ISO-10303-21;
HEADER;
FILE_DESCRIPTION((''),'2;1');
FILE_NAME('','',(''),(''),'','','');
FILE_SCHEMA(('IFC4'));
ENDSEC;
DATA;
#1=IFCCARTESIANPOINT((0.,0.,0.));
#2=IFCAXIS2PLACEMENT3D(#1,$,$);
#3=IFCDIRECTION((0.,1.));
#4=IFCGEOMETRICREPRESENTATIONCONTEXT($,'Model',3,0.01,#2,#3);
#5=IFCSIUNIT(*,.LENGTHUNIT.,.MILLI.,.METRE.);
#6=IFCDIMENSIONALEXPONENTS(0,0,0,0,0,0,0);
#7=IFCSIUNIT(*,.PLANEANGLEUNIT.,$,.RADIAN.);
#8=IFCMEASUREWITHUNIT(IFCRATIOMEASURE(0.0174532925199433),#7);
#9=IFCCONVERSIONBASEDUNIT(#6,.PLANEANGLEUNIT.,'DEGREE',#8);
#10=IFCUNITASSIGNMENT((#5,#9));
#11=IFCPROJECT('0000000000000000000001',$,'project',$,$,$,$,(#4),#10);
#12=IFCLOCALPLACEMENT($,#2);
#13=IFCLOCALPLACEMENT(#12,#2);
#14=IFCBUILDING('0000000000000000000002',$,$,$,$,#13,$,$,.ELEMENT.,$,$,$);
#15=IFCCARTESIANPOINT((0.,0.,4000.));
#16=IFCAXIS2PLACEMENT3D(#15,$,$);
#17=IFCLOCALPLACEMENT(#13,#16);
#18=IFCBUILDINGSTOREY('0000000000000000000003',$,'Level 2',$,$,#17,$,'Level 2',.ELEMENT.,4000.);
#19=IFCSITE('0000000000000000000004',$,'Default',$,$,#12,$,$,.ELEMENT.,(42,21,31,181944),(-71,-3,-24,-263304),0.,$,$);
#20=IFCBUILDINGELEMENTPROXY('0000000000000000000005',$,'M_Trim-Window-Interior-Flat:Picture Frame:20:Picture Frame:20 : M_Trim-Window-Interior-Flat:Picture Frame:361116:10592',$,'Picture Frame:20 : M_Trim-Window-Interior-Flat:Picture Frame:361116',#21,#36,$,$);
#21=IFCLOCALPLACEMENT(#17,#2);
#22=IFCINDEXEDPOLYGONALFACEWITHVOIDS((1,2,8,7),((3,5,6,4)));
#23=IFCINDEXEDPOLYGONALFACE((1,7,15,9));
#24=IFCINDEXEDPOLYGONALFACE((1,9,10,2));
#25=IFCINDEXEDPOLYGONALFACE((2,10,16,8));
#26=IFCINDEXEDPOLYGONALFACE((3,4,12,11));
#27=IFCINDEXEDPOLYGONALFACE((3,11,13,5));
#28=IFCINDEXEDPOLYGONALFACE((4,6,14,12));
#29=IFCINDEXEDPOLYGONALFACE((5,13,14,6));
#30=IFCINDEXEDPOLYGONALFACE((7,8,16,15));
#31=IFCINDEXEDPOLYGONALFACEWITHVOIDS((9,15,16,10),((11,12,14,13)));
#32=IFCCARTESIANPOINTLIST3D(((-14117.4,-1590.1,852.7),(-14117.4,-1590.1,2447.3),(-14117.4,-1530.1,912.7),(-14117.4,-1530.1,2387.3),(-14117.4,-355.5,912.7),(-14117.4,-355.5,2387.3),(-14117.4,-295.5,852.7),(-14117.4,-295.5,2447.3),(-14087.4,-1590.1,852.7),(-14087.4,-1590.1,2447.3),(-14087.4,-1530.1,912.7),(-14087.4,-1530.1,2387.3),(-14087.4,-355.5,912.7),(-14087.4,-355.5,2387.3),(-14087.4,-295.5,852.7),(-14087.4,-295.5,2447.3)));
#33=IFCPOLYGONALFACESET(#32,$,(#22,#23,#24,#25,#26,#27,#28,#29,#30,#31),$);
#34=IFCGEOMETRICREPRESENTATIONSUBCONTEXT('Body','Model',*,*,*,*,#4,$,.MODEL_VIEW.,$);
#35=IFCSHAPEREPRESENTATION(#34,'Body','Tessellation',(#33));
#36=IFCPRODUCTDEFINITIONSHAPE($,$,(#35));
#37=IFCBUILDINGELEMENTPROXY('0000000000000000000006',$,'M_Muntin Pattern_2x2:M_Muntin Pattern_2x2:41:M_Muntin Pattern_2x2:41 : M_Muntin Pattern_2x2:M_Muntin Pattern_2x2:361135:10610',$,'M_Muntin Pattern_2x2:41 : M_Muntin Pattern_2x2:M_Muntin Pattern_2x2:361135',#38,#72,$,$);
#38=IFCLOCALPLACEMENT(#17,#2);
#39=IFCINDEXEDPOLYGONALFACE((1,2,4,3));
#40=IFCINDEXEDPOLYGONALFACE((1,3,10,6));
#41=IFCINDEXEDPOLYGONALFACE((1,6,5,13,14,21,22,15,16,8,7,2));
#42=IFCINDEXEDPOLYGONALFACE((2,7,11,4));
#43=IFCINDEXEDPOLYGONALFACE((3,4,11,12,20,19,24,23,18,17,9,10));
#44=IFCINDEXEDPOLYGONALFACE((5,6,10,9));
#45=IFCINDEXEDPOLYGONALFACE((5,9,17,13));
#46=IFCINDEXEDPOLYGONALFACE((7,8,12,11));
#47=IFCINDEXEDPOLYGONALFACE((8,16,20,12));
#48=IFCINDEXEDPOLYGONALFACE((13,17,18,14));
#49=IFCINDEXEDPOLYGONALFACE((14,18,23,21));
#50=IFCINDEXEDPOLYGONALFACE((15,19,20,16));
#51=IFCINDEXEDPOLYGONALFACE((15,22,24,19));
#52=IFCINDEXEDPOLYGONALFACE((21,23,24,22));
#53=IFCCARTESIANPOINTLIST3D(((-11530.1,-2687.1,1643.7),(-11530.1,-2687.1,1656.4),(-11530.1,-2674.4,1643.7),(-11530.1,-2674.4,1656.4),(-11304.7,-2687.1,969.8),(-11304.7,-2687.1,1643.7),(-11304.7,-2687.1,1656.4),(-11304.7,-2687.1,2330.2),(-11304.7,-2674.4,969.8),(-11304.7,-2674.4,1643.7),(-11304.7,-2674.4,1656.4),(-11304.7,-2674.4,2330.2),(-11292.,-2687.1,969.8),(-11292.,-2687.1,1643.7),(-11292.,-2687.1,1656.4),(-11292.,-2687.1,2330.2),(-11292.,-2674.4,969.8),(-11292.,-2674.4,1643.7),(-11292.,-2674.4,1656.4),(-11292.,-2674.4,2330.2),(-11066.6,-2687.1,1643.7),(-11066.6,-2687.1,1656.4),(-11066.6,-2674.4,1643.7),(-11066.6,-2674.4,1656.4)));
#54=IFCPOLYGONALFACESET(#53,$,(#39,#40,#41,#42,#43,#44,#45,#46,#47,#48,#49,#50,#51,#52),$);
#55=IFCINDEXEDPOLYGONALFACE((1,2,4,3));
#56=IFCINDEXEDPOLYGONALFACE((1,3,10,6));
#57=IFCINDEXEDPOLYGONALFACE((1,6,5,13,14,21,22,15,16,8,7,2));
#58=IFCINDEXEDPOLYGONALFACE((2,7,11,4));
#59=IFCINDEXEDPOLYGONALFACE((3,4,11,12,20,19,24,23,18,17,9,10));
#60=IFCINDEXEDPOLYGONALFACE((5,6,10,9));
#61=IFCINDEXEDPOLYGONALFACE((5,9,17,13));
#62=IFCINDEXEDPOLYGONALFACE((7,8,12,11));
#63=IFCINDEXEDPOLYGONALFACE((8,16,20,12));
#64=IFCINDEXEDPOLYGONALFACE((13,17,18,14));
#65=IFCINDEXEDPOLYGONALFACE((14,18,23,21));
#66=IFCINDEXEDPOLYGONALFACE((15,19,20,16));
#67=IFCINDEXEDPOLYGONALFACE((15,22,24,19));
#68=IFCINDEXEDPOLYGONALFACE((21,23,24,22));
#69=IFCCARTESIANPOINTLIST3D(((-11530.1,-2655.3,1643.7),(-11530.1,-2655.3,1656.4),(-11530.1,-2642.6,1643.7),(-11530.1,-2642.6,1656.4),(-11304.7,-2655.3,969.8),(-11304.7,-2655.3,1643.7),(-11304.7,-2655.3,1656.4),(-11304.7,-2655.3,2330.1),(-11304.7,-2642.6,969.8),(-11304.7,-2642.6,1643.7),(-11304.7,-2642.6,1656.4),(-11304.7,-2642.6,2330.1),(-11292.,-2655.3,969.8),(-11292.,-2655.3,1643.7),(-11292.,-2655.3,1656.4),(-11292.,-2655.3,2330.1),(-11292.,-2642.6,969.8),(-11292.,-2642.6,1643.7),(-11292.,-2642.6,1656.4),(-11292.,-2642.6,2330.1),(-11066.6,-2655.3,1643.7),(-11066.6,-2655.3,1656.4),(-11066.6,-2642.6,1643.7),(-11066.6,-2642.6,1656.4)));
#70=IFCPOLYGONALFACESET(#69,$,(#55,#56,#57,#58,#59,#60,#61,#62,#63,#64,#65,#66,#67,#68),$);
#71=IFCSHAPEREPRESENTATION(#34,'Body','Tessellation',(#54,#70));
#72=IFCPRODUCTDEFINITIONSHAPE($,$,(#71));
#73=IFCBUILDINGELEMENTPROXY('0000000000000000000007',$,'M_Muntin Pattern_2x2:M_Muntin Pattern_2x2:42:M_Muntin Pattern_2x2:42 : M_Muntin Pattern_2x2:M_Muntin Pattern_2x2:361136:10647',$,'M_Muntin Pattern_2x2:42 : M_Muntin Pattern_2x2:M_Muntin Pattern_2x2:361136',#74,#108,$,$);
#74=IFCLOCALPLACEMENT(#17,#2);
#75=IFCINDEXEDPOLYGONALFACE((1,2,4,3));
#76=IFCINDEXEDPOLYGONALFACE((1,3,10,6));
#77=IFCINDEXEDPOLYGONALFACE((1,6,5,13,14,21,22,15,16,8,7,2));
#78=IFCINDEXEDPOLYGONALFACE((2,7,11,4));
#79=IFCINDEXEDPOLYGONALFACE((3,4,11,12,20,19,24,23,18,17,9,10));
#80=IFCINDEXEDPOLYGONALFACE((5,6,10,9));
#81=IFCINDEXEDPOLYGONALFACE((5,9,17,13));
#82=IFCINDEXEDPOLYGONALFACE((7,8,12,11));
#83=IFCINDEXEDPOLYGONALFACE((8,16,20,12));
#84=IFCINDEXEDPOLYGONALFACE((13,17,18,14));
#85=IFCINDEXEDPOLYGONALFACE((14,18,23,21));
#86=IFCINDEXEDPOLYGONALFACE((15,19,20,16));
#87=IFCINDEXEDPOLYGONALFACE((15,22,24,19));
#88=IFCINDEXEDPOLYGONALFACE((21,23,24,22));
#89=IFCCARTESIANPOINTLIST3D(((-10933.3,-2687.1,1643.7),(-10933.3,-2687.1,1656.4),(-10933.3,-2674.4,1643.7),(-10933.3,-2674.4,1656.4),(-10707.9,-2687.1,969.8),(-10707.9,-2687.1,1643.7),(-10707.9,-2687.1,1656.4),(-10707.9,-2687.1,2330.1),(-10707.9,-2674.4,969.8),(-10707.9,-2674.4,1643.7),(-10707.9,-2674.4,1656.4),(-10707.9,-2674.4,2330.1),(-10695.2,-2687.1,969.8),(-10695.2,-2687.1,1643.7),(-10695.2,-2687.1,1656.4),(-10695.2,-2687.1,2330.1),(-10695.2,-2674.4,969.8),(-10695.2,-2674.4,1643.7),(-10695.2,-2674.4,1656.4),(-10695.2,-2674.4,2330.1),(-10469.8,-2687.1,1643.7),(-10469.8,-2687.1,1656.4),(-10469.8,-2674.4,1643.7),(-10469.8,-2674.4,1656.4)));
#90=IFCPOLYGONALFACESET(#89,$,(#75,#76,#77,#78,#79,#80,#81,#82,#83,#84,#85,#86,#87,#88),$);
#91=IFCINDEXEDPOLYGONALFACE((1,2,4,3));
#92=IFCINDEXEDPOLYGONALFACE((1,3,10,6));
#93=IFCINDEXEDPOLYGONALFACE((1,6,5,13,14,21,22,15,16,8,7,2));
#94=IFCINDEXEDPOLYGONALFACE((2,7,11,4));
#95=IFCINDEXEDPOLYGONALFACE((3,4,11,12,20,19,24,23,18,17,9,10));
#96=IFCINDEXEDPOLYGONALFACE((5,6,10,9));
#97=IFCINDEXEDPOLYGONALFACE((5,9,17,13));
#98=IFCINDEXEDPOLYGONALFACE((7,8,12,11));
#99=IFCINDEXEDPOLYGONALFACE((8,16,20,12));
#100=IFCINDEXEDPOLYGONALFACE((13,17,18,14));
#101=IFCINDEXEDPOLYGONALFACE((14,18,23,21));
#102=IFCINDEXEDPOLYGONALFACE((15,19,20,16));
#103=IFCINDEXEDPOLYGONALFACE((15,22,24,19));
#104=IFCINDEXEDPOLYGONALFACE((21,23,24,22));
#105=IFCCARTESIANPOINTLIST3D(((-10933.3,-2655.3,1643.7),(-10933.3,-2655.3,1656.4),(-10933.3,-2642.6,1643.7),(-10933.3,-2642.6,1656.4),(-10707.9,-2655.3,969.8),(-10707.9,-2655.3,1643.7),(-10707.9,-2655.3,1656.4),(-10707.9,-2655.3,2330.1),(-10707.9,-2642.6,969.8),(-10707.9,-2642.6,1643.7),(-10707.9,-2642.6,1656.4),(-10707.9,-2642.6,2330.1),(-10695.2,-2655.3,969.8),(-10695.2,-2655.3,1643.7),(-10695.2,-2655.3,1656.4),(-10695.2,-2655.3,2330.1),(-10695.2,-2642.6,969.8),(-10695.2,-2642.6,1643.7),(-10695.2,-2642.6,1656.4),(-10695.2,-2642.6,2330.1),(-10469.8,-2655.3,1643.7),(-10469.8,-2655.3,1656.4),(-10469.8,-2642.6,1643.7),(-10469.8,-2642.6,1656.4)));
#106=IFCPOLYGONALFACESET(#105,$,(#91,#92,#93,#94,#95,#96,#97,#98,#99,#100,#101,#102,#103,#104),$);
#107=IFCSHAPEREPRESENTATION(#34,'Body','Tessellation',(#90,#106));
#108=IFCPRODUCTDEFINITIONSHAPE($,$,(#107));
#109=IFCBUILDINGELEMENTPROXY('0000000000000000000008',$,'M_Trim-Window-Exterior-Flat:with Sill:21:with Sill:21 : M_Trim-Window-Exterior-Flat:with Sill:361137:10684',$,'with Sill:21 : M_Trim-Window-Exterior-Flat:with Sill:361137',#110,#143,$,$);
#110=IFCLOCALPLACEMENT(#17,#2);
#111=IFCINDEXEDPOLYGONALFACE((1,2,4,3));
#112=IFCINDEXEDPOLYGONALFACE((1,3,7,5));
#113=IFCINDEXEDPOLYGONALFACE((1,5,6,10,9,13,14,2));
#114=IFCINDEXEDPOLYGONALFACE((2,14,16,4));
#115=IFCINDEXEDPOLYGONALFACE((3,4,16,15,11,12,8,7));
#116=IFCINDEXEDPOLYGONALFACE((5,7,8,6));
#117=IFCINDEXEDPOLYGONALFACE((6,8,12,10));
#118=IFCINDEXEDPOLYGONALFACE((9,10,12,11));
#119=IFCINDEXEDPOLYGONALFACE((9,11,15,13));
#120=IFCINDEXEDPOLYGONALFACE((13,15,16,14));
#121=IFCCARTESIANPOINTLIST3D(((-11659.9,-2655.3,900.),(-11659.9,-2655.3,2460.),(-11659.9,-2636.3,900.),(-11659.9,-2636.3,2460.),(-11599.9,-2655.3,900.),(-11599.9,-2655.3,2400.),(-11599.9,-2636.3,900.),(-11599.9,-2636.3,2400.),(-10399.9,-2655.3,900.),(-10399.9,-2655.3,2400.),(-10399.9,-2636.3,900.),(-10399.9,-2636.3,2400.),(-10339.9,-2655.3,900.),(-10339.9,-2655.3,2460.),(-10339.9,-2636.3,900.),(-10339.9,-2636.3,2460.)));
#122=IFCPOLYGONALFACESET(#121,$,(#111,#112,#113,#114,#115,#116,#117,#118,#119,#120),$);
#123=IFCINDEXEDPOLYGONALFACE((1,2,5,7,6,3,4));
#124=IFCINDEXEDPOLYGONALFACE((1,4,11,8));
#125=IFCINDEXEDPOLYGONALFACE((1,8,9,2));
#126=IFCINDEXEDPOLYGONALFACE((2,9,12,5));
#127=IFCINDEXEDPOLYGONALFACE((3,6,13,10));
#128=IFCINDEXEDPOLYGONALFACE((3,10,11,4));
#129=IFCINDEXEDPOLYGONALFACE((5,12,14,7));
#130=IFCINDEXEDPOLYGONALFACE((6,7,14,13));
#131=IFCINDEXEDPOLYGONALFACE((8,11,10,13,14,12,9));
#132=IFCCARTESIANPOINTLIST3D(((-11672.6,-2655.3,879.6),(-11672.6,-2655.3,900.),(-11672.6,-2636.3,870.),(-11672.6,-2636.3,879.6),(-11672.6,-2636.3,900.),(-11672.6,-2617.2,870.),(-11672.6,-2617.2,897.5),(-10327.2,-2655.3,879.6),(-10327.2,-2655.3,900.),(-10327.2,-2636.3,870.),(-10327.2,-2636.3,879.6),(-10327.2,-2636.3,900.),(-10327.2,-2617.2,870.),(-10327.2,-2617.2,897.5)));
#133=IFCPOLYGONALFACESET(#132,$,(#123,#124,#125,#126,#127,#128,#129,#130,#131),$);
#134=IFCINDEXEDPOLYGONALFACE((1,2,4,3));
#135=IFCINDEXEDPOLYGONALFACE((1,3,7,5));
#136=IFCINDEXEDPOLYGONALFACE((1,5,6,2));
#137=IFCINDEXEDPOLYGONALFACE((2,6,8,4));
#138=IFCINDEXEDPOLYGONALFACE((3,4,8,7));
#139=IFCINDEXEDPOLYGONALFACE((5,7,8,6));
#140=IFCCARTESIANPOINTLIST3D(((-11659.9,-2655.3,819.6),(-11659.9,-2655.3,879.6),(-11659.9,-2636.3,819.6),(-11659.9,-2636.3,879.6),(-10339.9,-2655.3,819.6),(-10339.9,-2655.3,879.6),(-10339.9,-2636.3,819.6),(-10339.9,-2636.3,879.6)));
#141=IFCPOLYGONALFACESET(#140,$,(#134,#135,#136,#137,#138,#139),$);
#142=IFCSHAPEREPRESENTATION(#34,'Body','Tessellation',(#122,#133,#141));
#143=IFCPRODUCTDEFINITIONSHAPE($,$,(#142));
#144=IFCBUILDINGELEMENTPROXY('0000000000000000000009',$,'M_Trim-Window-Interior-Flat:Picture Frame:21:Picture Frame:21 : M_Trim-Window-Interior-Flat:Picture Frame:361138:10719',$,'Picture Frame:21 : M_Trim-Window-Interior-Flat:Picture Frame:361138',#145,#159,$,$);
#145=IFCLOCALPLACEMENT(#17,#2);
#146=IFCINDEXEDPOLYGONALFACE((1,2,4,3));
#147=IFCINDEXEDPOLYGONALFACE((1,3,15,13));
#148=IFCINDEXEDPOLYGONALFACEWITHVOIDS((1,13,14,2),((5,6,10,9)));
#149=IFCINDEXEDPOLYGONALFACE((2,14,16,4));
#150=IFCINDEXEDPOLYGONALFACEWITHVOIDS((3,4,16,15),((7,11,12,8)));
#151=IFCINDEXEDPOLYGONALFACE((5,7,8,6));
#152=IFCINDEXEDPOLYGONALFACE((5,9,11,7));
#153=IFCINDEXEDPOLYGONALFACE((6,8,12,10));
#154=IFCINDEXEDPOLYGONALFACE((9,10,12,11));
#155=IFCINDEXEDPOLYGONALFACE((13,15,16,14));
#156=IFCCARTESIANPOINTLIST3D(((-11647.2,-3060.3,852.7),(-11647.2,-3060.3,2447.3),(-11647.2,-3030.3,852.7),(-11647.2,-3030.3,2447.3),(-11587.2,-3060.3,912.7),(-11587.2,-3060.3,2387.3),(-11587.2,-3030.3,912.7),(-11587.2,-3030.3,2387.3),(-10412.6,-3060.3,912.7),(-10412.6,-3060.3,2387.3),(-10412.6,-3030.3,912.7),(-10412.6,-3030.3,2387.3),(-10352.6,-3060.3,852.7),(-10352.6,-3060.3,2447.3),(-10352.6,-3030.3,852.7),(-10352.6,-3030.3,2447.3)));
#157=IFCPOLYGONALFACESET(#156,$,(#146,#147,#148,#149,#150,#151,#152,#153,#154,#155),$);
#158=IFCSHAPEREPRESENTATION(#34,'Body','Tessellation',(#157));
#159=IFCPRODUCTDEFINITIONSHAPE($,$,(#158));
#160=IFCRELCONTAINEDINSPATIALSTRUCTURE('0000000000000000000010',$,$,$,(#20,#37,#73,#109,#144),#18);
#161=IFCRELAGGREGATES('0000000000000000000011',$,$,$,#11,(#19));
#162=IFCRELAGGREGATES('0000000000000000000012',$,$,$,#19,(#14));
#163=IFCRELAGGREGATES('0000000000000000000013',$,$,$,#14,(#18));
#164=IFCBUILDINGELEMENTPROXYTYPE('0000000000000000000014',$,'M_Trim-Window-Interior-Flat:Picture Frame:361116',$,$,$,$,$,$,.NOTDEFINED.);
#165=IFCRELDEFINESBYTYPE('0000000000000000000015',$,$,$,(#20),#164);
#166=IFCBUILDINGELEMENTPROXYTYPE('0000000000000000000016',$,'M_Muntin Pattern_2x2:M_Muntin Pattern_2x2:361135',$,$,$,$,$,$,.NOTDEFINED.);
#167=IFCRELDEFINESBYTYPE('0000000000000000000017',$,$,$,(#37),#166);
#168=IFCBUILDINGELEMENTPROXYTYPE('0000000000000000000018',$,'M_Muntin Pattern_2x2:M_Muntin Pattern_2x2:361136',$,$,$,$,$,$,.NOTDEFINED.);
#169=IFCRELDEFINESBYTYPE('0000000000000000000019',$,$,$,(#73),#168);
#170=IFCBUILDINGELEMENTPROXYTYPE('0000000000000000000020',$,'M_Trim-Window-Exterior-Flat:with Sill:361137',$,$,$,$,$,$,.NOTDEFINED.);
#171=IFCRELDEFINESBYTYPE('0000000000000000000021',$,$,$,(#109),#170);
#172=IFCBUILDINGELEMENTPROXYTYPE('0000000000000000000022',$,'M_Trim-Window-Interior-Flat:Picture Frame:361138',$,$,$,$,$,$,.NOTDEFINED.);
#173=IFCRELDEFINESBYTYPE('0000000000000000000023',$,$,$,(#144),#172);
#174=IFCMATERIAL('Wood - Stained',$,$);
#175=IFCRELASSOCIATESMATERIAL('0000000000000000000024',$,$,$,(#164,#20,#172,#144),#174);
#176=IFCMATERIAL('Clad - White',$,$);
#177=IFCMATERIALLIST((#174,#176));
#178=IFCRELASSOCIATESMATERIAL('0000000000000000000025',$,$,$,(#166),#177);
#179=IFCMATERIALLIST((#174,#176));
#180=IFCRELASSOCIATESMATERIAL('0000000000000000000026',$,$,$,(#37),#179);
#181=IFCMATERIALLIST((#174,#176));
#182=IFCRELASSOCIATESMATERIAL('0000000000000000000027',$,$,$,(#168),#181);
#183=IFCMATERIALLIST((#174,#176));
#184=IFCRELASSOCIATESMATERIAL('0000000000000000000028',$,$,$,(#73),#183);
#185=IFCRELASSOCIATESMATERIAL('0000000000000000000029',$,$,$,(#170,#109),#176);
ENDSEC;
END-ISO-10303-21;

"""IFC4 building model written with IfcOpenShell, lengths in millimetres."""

from ifc_helpers import new_model, entity, si_unit, converted_unit, direction, frame, origin, origin_2d_with_axis, place, context, subcontext, project, spatial, polyline, rectangle, outline, extrude, source, transform, mapped, material, material_list, type_object, type_shapes, element, save


model = new_model("IFC4")

# Units and contexts
model_context = context("Model", 3, precision=0.01, world=origin(), true_north=direction((0.0, 1.0)))
body_context = subcontext(model_context, "Body", "Model", "MODEL_VIEW")
ifc_project = project(units=[si_unit("LENGTHUNIT", "METRE", prefix="MILLI"), converted_unit("PLANEANGLEUNIT", "DEGREE", entity("IfcRatioMeasure", 0.0174532925199433), si_unit("PLANEANGLEUNIT", "RADIAN"), dimensions=[0, 0, 0, 0, 0, 0, 0])], contexts=[model_context])

# Site, building, storey
site_placement = place(None, origin())
site = spatial("IfcSite", under=ifc_project, at=site_placement, Name="Default", CompositionType="ELEMENT", RefLatitude=(42, 21, 31, 181944), RefLongitude=(-71, -3, -24, -263304), RefElevation=0.0)
building_placement = place(site_placement, origin())
building = spatial("IfcBuilding", under=site, at=building_placement, CompositionType="ELEMENT")
storey_placement = place(building_placement, frame((0.0, 0.0, 4000.0)))
storey = spatial("IfcBuildingStorey", under=building, at=storey_placement, Name="Level 2", LongName="Level 2", CompositionType="ELEMENT", Elevation=4000.0)

# Building element proxies
ifc_material_1 = material(Name="Wood - Stained")
ifc_material_2 = material(Name="Clad - White")
building_element_proxy_type_1 = type_object("IfcBuildingElementProxyType", Name="M_Trim-Window-Interior-Flat:Picture Frame:361116", PredefinedType="NOTDEFINED", material=ifc_material_1)
shared_shape_1 = source(origin(), body_context, "Body", "SweptSolid", [
    extrude(outline(polyline([(-647.3, -797.3), (647.3, -797.3), (647.3, 797.3), (-647.3, 797.3), (-647.3, -797.3)]), holes=[polyline([(587.3, 737.3), (587.3, -737.3), (-587.3, -737.3), (-587.3, 737.3), (587.3, 737.3)])]), frame((-14117.4, -942.8, 5650.0), z_axis=(1.0, 0.0, 0.0), x_axis=(0.0, -1.0, 0.0)), (0.0, 0.0, 1.0), 30.0),
])
type_shapes(building_element_proxy_type_1, [shared_shape_1])
proxy_1_placement = place(storey_placement, frame((0.0, 0.0, -4000.0)))
element("IfcBuildingElementProxy", 1, at=proxy_1_placement, inside=storey, type_object=building_element_proxy_type_1, material=ifc_material_1, Name="M_Trim-Window-Interior-Flat:Picture Frame:20:Picture Frame:20 : M_Trim-Window-Interior-Flat:Picture Frame:361116:10592", ObjectType="Picture Frame:20 : M_Trim-Window-Interior-Flat:Picture Frame:361116", context=body_context, shape_type="MappedRepresentation", body=[
    mapped(shared_shape_1, transform((0.0, 0.0, 0.0), scale=1.0)),
])
ifc_material_list_1 = material_list([ifc_material_1, ifc_material_2])
ifc_material_list_2 = material_list([ifc_material_1, ifc_material_2])
building_element_proxy_type_2 = type_object("IfcBuildingElementProxyType", Name="M_Muntin Pattern_2x2:M_Muntin Pattern_2x2:361135", PredefinedType="NOTDEFINED", material=ifc_material_list_2)
shared_shape_2 = source(origin(), body_context, "Body", "SweptSolid", [
    extrude(outline(polyline([(-6.4, -680.2), (6.3, -680.2), (6.3, -6.4), (231.7, -6.4), (231.7, 6.3), (6.3, 6.3), (6.3, 680.2), (-6.4, 680.2), (-6.4, 6.3), (-231.7, 6.3), (-231.7, -6.4), (-6.4, -6.4), (-6.4, -680.2)])), frame((-11298.4, -2687.1, 5650.0), z_axis=(0.0, 1.0, 0.0), x_axis=(1.0, 0.0, 0.0)), (0.0, 0.0, 1.0), 12.7),
    extrude(outline(polyline([(-6.4, -680.1), (6.3, -680.1), (6.3, -6.4), (231.7, -6.4), (231.7, 6.3), (6.3, 6.3), (6.3, 680.2), (-6.4, 680.2), (-6.4, 6.3), (-231.7, 6.3), (-231.7, -6.4), (-6.4, -6.4), (-6.4, -680.1)])), frame((-11298.4, -2655.3, 5650.0), z_axis=(0.0, 1.0, 0.0), x_axis=(1.0, 0.0, 0.0)), (0.0, 0.0, 1.0), 12.7),
])
type_shapes(building_element_proxy_type_2, [shared_shape_2])
proxy_2_placement = place(storey_placement, frame((0.0, 0.0, -4000.0)))
element("IfcBuildingElementProxy", 2, at=proxy_2_placement, inside=storey, type_object=building_element_proxy_type_2, material=ifc_material_list_1, Name="M_Muntin Pattern_2x2:M_Muntin Pattern_2x2:41:M_Muntin Pattern_2x2:41 : M_Muntin Pattern_2x2:M_Muntin Pattern_2x2:361135:10610", ObjectType="M_Muntin Pattern_2x2:41 : M_Muntin Pattern_2x2:M_Muntin Pattern_2x2:361135", context=body_context, shape_type="MappedRepresentation", body=[
    mapped(shared_shape_2, transform((0.0, 0.0, 0.0), scale=1.0)),
])
ifc_material_list_3 = material_list([ifc_material_1, ifc_material_2])
ifc_material_list_4 = material_list([ifc_material_1, ifc_material_2])
building_element_proxy_type_3 = type_object("IfcBuildingElementProxyType", Name="M_Muntin Pattern_2x2:M_Muntin Pattern_2x2:361136", PredefinedType="NOTDEFINED", material=ifc_material_list_4)
shared_shape_3 = source(origin(), body_context, "Body", "SweptSolid", [
    extrude(outline(polyline([(-680.1, 6.4), (-680.1, -6.3), (-6.4, -6.3), (-6.4, -231.7), (6.3, -231.7), (6.3, -6.3), (680.2, -6.3), (680.2, 6.4), (6.3, 6.4), (6.3, 231.7), (-6.4, 231.7), (-6.4, 6.4), (-680.1, 6.4)])), frame((-10701.5, -2687.1, 5650.0), z_axis=(0.0, -1.0, 0.0), x_axis=(0.0, 0.0, -1.0)), (0.0, 0.0, -1.0), 12.7),
    extrude(outline(polyline([(-680.1, 6.4), (-680.1, -6.3), (-6.4, -6.3), (-6.4, -231.7), (6.3, -231.7), (6.3, -6.3), (680.2, -6.3), (680.2, 6.4), (6.3, 6.4), (6.3, 231.7), (-6.4, 231.7), (-6.4, 6.4), (-680.1, 6.4)])), frame((-10701.5, -2655.3, 5650.0), z_axis=(0.0, -1.0, 0.0), x_axis=(0.0, 0.0, -1.0)), (0.0, 0.0, -1.0), 12.7),
])
type_shapes(building_element_proxy_type_3, [shared_shape_3])
proxy_3_placement = place(storey_placement, frame((0.0, 0.0, -4000.0)))
element("IfcBuildingElementProxy", 3, at=proxy_3_placement, inside=storey, type_object=building_element_proxy_type_3, material=ifc_material_list_3, Name="M_Muntin Pattern_2x2:M_Muntin Pattern_2x2:42:M_Muntin Pattern_2x2:42 : M_Muntin Pattern_2x2:M_Muntin Pattern_2x2:361136:10647", ObjectType="M_Muntin Pattern_2x2:42 : M_Muntin Pattern_2x2:M_Muntin Pattern_2x2:361136", context=body_context, shape_type="MappedRepresentation", body=[
    mapped(shared_shape_3, transform((0.0, 0.0, 0.0), scale=1.0)),
])
building_element_proxy_type_4 = type_object("IfcBuildingElementProxyType", Name="M_Trim-Window-Exterior-Flat:with Sill:361137", PredefinedType="NOTDEFINED", material=ifc_material_2)
shared_shape_4 = source(origin(), body_context, "Body", "SweptSolid", [
    extrude(outline(polyline([(-660.0, -765.0), (-600.0, -765.0), (-600.0, 735.0), (600.0, 735.0), (600.0, -765.0), (660.0, -765.0), (660.0, 795.0), (-660.0, 795.0), (-660.0, -765.0)])), frame((-10999.9, -2655.3, 5665.0), z_axis=(0.0, 1.0, 0.0), x_axis=(-1.0, 0.0, 0.0)), (0.0, 0.0, 1.0), 19.1),
    extrude(outline(polyline([(0.0, -15.2), (19.0, -15.2), (19.0, 12.3), (0.0, 14.8), (-19.0, 14.8), (-19.0, -5.7), (0.0, -5.7), (0.0, -15.2)])), frame((-11672.6, -2636.3, 4885.2), z_axis=(1.0, 0.0, 0.0), x_axis=(0.0, 1.0, 0.0)), (0.0, 0.0, 1.0), 1345.4),
    extrude(rectangle(XDim=19.1, YDim=1320.0, at=origin_2d_with_axis()), frame((-10999.9, -2645.8, 4819.6), z_axis=(0.0, 0.0, 1.0), x_axis=(0.0, -1.0, 0.0)), (0.0, 0.0, 1.0), 60.0),
])
type_shapes(building_element_proxy_type_4, [shared_shape_4])
proxy_4_placement = place(storey_placement, frame((0.0, 0.0, -4000.0)))
element("IfcBuildingElementProxy", 4, at=proxy_4_placement, inside=storey, type_object=building_element_proxy_type_4, material=ifc_material_2, Name="M_Trim-Window-Exterior-Flat:with Sill:21:with Sill:21 : M_Trim-Window-Exterior-Flat:with Sill:361137:10684", ObjectType="with Sill:21 : M_Trim-Window-Exterior-Flat:with Sill:361137", context=body_context, shape_type="MappedRepresentation", body=[
    mapped(shared_shape_4, transform((0.0, 0.0, 0.0), scale=1.0)),
])
building_element_proxy_type_5 = type_object("IfcBuildingElementProxyType", Name="M_Trim-Window-Interior-Flat:Picture Frame:361138", PredefinedType="NOTDEFINED", material=ifc_material_1)
shared_shape_5 = source(origin(), body_context, "Body", "SweptSolid", [
    extrude(outline(polyline([(-647.3, -797.3), (647.3, -797.3), (647.3, 797.3), (-647.3, 797.3), (-647.3, -797.3)]), holes=[polyline([(587.3, 737.3), (587.3, -737.3), (-587.3, -737.3), (-587.3, 737.3), (587.3, 737.3)])]), frame((-10999.9, -3060.3, 5650.0), z_axis=(0.0, 1.0, 0.0), x_axis=(1.0, 0.0, 0.0)), (0.0, 0.0, 1.0), 30.0),
])
type_shapes(building_element_proxy_type_5, [shared_shape_5])
proxy_5_placement = place(storey_placement, frame((0.0, 0.0, -4000.0)))
element("IfcBuildingElementProxy", 5, at=proxy_5_placement, inside=storey, type_object=building_element_proxy_type_5, material=ifc_material_1, Name="M_Trim-Window-Interior-Flat:Picture Frame:21:Picture Frame:21 : M_Trim-Window-Interior-Flat:Picture Frame:361138:10719", ObjectType="Picture Frame:21 : M_Trim-Window-Interior-Flat:Picture Frame:361138", context=body_context, shape_type="MappedRepresentation", body=[
    mapped(shared_shape_5, transform((0.0, 0.0, 0.0), scale=1.0)),
])

save(model, "model.ifc")
